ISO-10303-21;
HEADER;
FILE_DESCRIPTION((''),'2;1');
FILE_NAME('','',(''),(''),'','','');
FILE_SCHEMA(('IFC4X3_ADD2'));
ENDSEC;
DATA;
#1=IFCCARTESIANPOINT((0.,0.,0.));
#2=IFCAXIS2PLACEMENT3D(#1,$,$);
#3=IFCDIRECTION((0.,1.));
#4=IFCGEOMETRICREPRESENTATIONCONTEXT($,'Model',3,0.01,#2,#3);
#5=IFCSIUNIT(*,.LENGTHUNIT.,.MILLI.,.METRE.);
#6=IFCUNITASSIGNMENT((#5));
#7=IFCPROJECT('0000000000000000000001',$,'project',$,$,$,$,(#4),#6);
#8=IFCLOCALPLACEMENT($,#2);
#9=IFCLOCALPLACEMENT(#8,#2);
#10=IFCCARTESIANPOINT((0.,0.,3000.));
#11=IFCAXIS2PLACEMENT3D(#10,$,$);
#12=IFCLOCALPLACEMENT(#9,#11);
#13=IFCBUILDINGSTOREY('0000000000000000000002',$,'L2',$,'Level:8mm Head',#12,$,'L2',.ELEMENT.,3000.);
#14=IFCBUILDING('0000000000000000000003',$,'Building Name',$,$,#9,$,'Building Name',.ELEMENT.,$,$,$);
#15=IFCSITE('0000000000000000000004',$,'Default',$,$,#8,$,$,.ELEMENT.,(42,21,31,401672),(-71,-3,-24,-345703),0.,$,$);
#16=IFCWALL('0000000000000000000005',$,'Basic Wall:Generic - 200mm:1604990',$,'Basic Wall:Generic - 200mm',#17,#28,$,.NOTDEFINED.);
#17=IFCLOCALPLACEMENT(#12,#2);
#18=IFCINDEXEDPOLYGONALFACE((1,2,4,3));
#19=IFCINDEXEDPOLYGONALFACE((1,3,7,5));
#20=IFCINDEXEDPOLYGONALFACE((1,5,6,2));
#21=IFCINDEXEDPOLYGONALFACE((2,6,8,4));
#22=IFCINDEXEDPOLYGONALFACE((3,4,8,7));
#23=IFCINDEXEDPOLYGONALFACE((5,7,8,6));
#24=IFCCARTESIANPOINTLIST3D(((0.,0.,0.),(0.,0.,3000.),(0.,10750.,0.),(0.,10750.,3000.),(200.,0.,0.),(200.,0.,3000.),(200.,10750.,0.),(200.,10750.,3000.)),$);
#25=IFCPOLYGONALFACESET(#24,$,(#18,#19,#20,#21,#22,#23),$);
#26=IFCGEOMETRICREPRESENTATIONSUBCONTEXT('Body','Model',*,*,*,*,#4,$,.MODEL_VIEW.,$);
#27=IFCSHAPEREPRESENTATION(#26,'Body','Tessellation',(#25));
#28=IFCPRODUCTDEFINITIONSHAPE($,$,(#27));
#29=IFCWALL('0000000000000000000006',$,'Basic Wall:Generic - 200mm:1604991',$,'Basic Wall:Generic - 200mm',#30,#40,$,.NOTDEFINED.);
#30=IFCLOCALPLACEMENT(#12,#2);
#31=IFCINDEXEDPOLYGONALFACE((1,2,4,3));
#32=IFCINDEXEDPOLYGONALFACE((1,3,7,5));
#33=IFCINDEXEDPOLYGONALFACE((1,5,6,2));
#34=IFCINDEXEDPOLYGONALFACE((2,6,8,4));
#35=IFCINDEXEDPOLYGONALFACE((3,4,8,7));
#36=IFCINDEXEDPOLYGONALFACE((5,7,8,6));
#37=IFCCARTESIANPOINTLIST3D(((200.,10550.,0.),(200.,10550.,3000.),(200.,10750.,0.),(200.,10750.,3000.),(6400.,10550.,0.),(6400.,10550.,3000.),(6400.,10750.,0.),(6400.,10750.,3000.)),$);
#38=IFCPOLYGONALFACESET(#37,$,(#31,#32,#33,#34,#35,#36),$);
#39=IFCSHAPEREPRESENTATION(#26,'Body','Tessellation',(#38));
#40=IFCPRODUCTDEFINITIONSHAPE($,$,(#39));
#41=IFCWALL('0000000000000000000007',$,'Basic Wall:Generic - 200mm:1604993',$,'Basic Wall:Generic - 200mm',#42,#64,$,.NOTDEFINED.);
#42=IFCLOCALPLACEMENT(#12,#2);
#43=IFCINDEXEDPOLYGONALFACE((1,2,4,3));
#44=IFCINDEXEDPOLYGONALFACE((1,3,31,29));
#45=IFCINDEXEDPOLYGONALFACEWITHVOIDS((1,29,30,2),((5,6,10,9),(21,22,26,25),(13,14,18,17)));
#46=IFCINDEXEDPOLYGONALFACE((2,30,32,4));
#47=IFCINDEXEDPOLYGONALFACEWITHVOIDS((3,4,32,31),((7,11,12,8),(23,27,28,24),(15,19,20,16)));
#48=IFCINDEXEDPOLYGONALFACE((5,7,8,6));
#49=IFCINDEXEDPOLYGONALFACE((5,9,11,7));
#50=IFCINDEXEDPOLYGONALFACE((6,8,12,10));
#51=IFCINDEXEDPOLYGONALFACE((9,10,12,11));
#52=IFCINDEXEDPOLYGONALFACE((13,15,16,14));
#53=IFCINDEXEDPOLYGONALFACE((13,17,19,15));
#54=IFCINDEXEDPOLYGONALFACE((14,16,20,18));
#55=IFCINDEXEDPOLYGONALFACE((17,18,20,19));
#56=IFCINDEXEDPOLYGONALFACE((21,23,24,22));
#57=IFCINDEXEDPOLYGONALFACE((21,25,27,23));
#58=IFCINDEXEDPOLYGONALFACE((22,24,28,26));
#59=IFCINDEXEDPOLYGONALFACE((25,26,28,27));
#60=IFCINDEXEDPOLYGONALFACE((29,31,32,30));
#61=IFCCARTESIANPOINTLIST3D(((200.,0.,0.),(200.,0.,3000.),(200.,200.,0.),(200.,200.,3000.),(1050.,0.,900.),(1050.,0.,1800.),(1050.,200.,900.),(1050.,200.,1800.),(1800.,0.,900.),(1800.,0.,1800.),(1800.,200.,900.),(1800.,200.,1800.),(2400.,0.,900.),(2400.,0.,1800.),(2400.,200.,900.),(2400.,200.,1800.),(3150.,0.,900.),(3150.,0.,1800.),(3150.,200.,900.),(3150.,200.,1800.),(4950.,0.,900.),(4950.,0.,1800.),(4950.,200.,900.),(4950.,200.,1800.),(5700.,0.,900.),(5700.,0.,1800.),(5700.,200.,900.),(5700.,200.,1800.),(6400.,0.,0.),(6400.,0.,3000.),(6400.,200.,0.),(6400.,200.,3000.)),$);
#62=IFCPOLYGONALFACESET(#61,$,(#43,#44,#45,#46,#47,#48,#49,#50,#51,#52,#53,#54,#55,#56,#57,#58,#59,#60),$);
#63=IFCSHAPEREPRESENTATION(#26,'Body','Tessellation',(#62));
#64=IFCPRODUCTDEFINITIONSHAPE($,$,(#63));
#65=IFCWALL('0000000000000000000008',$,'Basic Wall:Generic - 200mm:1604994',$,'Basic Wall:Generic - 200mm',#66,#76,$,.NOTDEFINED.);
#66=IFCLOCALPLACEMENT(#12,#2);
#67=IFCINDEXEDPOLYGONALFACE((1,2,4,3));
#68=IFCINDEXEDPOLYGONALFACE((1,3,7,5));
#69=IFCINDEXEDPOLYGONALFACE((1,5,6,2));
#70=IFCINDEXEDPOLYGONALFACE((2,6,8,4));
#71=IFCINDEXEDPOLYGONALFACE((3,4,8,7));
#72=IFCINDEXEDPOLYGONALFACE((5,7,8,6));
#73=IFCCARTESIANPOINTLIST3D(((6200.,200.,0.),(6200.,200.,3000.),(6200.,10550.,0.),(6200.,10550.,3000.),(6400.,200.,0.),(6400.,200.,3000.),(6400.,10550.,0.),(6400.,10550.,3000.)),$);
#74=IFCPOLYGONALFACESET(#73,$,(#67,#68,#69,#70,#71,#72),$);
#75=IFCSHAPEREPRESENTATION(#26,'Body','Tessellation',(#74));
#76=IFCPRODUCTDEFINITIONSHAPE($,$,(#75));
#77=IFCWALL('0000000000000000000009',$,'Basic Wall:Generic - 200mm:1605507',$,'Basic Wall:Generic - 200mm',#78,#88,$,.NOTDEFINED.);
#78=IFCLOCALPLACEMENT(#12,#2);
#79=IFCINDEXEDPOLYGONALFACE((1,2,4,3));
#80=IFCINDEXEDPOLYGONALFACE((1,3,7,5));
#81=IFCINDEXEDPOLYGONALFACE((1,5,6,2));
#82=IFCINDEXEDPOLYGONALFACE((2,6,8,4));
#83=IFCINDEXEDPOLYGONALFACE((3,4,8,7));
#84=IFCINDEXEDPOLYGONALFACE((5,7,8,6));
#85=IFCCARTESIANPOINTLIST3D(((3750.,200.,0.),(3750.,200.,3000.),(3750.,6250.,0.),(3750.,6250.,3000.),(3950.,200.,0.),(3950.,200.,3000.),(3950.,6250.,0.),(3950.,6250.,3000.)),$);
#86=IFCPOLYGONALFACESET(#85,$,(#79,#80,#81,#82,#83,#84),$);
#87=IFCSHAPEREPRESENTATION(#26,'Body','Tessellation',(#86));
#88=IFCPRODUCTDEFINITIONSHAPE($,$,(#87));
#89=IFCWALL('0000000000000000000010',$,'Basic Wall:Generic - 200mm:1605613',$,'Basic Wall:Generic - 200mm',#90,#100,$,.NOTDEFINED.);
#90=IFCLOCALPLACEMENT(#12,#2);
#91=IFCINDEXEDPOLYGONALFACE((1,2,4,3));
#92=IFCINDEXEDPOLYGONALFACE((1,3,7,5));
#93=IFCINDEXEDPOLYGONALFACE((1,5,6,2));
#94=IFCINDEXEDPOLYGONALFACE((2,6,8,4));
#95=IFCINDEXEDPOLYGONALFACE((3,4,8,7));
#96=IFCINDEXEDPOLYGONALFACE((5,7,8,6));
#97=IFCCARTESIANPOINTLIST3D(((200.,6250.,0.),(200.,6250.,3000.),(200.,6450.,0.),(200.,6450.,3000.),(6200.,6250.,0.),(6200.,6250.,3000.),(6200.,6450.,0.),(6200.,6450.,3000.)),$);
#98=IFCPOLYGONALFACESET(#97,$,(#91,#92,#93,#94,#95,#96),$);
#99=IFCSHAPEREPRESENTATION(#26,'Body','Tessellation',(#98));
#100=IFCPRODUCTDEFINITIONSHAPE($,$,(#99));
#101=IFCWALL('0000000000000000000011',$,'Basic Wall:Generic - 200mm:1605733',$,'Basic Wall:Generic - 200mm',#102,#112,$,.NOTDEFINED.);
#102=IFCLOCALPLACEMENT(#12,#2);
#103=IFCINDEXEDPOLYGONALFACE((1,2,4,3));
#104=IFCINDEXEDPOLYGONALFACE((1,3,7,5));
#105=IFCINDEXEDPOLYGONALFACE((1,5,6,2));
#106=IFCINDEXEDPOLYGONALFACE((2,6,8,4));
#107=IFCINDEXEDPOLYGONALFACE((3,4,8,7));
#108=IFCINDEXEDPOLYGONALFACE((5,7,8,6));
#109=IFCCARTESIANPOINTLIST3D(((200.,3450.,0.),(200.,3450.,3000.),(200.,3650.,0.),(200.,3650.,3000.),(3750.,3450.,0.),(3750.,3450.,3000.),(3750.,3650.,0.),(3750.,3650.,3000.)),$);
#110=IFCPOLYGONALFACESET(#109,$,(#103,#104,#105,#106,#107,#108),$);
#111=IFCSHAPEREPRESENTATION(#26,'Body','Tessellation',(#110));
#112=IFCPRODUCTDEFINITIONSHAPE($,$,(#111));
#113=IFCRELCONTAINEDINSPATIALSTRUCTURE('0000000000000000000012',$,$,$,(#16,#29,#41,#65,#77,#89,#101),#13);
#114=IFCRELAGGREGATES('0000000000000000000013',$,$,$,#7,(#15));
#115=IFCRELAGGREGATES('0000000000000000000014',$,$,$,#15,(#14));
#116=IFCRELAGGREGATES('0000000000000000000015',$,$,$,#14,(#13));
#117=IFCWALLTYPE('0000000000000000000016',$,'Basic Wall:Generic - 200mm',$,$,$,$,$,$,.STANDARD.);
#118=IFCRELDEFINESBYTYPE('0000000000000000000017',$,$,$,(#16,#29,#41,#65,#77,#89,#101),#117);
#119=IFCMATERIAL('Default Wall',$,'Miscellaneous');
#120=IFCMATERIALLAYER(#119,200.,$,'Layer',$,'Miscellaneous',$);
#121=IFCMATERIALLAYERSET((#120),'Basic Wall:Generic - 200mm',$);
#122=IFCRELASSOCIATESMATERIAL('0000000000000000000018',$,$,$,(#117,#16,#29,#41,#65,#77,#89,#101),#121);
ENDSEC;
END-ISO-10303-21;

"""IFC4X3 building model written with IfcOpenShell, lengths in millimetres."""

from ifc_helpers import new_model, si_unit, direction, frame, frame_2d, origin, place, context, subcontext, project, spatial, rectangle, extrude, material, layer, layer_set, type_object, element, save


model = new_model("IFC4X3")

# Units and contexts
model_context = context("Model", 3, precision=0.01, world=origin(), true_north=direction((0.0, 1.0)))
body_context = subcontext(model_context, "Body", "Model", "MODEL_VIEW")
ifc_project = project(units=[si_unit("LENGTHUNIT", "METRE", prefix="MILLI")], contexts=[model_context])

# Site, building, storey
site_placement = place(None, origin())
site = spatial("IfcSite", under=ifc_project, at=site_placement, Name="Default", CompositionType="ELEMENT", RefLatitude=(42, 21, 31, 401672), RefLongitude=(-71, -3, -24, -345703), RefElevation=0.0)
building_placement = place(site_placement, origin())
building = spatial("IfcBuilding", under=site, at=building_placement, Name="Building Name", LongName="Building Name", CompositionType="ELEMENT")
storey_placement = place(building_placement, frame((0.0, 0.0, 3000.0)))
storey = spatial("IfcBuildingStorey", under=building, at=storey_placement, Name="L2", ObjectType="Level:8mm Head", LongName="L2", CompositionType="ELEMENT", Elevation=3000.0)

# Walls
ifc_material = material(Name="Default Wall", Category="Miscellaneous")
ifc_layer = layer(ifc_material, 200.0, Name="Layer", Category="Miscellaneous")
ifc_layer_set = layer_set([ifc_layer], Name="Basic Wall:Generic - 200mm")
wall_type = type_object("IfcWallType", Name="Basic Wall:Generic - 200mm", PredefinedType="STANDARD", material=ifc_layer_set)
wall_1_placement = place(storey_placement, frame((100.0, 0.0, 0.0), z_axis=(0.0, 0.0, 1.0), x_axis=(0.0, 1.0, 0.0)))
element("IfcWall", 1, at=wall_1_placement, inside=storey, type_object=wall_type, material=ifc_layer_set, Name="Basic Wall:Generic - 200mm:1604990", ObjectType="Basic Wall:Generic - 200mm", PredefinedType="NOTDEFINED", context=body_context, shape_type="SweptSolid", body=[
    extrude(rectangle(XDim=10750.0, YDim=200.0, at=frame_2d((5375.0, 0.0), x_axis=(-1.0, 0.0))), origin(), (0.0, 0.0, 1.0), 3000.0),
])
wall_2_placement = place(storey_placement, frame((200.0, 10650.0, 0.0)))
element("IfcWall", 2, at=wall_2_placement, inside=storey, type_object=wall_type, material=ifc_layer_set, Name="Basic Wall:Generic - 200mm:1604991", ObjectType="Basic Wall:Generic - 200mm", PredefinedType="NOTDEFINED", context=body_context, shape_type="SweptSolid", body=[
    extrude(rectangle(XDim=6200.0, YDim=200.0, at=frame_2d((3100.0, 0.0), x_axis=(-1.0, 0.0))), origin(), (0.0, 0.0, 1.0), 3000.0),
])

# Wall, openings
wall_3_placement = place(storey_placement, frame((6400.0, 100.0, 0.0), z_axis=(0.0, 0.0, 1.0), x_axis=(-1.0, 0.0, 0.0)))
wall_3 = element("IfcWall", 3, at=wall_3_placement, inside=storey, type_object=wall_type, material=ifc_layer_set, Name="Basic Wall:Generic - 200mm:1604993", ObjectType="Basic Wall:Generic - 200mm", PredefinedType="NOTDEFINED", context=body_context, shape_type="SweptSolid", body=[
    extrude(rectangle(XDim=6200.0, YDim=200.0, at=frame_2d((3100.0, 0.0), x_axis=(-1.0, 0.0))), origin(), (0.0, 0.0, 1.0), 3000.0),
])
opening_1_placement = place(wall_3_placement, frame((4600.0, -100.0, 900.0)))
element("IfcOpeningElement", 4, at=opening_1_placement, cuts=wall_3, PredefinedType="OPENING", context=body_context, shape_type="SweptSolid", body=[
    extrude(rectangle(XDim=900.0, YDim=750.0, at=frame_2d((450.0, 375.0), x_axis=(-1.0, 0.0))), frame((0.0, 0.0, 0.0), z_axis=(0.0, 1.0, 0.0), x_axis=(0.0, 0.0, 1.0)), (0.0, 0.0, 1.0), 200.0),
])
opening_2_placement = place(wall_3_placement, frame((3250.0, -100.0, 900.0)))
element("IfcOpeningElement", 5, at=opening_2_placement, cuts=wall_3, PredefinedType="OPENING", context=body_context, shape_type="SweptSolid", body=[
    extrude(rectangle(XDim=900.0, YDim=750.0, at=frame_2d((450.0, 375.0), x_axis=(-1.0, 0.0))), frame((0.0, 0.0, 0.0), z_axis=(0.0, 1.0, 0.0), x_axis=(0.0, 0.0, 1.0)), (0.0, 0.0, 1.0), 200.0),
])
opening_3_placement = place(wall_3_placement, frame((700.0, -100.0, 900.0)))
element("IfcOpeningElement", 6, at=opening_3_placement, cuts=wall_3, PredefinedType="OPENING", context=body_context, shape_type="SweptSolid", body=[
    extrude(rectangle(XDim=900.0, YDim=750.0, at=frame_2d((450.0, 375.0), x_axis=(-1.0, 0.0))), frame((0.0, 0.0, 0.0), z_axis=(0.0, 1.0, 0.0), x_axis=(0.0, 0.0, 1.0)), (0.0, 0.0, 1.0), 200.0),
])

# Walls
wall_4_placement = place(storey_placement, frame((6300.0, 200.0, 0.0), z_axis=(0.0, 0.0, 1.0), x_axis=(0.0, 1.0, 0.0)))
element("IfcWall", 7, at=wall_4_placement, inside=storey, type_object=wall_type, material=ifc_layer_set, Name="Basic Wall:Generic - 200mm:1604994", ObjectType="Basic Wall:Generic - 200mm", PredefinedType="NOTDEFINED", context=body_context, shape_type="SweptSolid", body=[
    extrude(rectangle(XDim=10350.0, YDim=200.0, at=frame_2d((5175.0, 0.0), x_axis=(-1.0, 0.0))), origin(), (0.0, 0.0, 1.0), 3000.0),
])
wall_5_placement = place(storey_placement, frame((3850.0, 200.0, 0.0), z_axis=(0.0, 0.0, 1.0), x_axis=(0.0, 1.0, 0.0)))
element("IfcWall", 8, at=wall_5_placement, inside=storey, type_object=wall_type, material=ifc_layer_set, Name="Basic Wall:Generic - 200mm:1605507", ObjectType="Basic Wall:Generic - 200mm", PredefinedType="NOTDEFINED", context=body_context, shape_type="SweptSolid", body=[
    extrude(rectangle(XDim=6050.0, YDim=200.0, at=frame_2d((3025.0, 0.0), x_axis=(-1.0, 0.0))), origin(), (0.0, 0.0, 1.0), 3000.0),
])
wall_6_placement = place(storey_placement, frame((6200.0, 6350.0, 0.0), z_axis=(0.0, 0.0, 1.0), x_axis=(-1.0, 0.0, 0.0)))
element("IfcWall", 9, at=wall_6_placement, inside=storey, type_object=wall_type, material=ifc_layer_set, Name="Basic Wall:Generic - 200mm:1605613", ObjectType="Basic Wall:Generic - 200mm", PredefinedType="NOTDEFINED", context=body_context, shape_type="SweptSolid", body=[
    extrude(rectangle(XDim=6000.0, YDim=200.0, at=frame_2d((3000.0, 0.0), x_axis=(-1.0, 0.0))), origin(), (0.0, 0.0, 1.0), 3000.0),
])
wall_7_placement = place(storey_placement, frame((3750.0, 3550.0, 0.0), z_axis=(0.0, 0.0, 1.0), x_axis=(-1.0, 0.0, 0.0)))
element("IfcWall", 10, at=wall_7_placement, inside=storey, type_object=wall_type, material=ifc_layer_set, Name="Basic Wall:Generic - 200mm:1605733", ObjectType="Basic Wall:Generic - 200mm", PredefinedType="NOTDEFINED", context=body_context, shape_type="SweptSolid", body=[
    extrude(rectangle(XDim=3550.0, YDim=200.0, at=frame_2d((1775.0, 0.0), x_axis=(-1.0, 0.0))), origin(), (0.0, 0.0, 1.0), 3000.0),
])

save(model, "model.ifc")
